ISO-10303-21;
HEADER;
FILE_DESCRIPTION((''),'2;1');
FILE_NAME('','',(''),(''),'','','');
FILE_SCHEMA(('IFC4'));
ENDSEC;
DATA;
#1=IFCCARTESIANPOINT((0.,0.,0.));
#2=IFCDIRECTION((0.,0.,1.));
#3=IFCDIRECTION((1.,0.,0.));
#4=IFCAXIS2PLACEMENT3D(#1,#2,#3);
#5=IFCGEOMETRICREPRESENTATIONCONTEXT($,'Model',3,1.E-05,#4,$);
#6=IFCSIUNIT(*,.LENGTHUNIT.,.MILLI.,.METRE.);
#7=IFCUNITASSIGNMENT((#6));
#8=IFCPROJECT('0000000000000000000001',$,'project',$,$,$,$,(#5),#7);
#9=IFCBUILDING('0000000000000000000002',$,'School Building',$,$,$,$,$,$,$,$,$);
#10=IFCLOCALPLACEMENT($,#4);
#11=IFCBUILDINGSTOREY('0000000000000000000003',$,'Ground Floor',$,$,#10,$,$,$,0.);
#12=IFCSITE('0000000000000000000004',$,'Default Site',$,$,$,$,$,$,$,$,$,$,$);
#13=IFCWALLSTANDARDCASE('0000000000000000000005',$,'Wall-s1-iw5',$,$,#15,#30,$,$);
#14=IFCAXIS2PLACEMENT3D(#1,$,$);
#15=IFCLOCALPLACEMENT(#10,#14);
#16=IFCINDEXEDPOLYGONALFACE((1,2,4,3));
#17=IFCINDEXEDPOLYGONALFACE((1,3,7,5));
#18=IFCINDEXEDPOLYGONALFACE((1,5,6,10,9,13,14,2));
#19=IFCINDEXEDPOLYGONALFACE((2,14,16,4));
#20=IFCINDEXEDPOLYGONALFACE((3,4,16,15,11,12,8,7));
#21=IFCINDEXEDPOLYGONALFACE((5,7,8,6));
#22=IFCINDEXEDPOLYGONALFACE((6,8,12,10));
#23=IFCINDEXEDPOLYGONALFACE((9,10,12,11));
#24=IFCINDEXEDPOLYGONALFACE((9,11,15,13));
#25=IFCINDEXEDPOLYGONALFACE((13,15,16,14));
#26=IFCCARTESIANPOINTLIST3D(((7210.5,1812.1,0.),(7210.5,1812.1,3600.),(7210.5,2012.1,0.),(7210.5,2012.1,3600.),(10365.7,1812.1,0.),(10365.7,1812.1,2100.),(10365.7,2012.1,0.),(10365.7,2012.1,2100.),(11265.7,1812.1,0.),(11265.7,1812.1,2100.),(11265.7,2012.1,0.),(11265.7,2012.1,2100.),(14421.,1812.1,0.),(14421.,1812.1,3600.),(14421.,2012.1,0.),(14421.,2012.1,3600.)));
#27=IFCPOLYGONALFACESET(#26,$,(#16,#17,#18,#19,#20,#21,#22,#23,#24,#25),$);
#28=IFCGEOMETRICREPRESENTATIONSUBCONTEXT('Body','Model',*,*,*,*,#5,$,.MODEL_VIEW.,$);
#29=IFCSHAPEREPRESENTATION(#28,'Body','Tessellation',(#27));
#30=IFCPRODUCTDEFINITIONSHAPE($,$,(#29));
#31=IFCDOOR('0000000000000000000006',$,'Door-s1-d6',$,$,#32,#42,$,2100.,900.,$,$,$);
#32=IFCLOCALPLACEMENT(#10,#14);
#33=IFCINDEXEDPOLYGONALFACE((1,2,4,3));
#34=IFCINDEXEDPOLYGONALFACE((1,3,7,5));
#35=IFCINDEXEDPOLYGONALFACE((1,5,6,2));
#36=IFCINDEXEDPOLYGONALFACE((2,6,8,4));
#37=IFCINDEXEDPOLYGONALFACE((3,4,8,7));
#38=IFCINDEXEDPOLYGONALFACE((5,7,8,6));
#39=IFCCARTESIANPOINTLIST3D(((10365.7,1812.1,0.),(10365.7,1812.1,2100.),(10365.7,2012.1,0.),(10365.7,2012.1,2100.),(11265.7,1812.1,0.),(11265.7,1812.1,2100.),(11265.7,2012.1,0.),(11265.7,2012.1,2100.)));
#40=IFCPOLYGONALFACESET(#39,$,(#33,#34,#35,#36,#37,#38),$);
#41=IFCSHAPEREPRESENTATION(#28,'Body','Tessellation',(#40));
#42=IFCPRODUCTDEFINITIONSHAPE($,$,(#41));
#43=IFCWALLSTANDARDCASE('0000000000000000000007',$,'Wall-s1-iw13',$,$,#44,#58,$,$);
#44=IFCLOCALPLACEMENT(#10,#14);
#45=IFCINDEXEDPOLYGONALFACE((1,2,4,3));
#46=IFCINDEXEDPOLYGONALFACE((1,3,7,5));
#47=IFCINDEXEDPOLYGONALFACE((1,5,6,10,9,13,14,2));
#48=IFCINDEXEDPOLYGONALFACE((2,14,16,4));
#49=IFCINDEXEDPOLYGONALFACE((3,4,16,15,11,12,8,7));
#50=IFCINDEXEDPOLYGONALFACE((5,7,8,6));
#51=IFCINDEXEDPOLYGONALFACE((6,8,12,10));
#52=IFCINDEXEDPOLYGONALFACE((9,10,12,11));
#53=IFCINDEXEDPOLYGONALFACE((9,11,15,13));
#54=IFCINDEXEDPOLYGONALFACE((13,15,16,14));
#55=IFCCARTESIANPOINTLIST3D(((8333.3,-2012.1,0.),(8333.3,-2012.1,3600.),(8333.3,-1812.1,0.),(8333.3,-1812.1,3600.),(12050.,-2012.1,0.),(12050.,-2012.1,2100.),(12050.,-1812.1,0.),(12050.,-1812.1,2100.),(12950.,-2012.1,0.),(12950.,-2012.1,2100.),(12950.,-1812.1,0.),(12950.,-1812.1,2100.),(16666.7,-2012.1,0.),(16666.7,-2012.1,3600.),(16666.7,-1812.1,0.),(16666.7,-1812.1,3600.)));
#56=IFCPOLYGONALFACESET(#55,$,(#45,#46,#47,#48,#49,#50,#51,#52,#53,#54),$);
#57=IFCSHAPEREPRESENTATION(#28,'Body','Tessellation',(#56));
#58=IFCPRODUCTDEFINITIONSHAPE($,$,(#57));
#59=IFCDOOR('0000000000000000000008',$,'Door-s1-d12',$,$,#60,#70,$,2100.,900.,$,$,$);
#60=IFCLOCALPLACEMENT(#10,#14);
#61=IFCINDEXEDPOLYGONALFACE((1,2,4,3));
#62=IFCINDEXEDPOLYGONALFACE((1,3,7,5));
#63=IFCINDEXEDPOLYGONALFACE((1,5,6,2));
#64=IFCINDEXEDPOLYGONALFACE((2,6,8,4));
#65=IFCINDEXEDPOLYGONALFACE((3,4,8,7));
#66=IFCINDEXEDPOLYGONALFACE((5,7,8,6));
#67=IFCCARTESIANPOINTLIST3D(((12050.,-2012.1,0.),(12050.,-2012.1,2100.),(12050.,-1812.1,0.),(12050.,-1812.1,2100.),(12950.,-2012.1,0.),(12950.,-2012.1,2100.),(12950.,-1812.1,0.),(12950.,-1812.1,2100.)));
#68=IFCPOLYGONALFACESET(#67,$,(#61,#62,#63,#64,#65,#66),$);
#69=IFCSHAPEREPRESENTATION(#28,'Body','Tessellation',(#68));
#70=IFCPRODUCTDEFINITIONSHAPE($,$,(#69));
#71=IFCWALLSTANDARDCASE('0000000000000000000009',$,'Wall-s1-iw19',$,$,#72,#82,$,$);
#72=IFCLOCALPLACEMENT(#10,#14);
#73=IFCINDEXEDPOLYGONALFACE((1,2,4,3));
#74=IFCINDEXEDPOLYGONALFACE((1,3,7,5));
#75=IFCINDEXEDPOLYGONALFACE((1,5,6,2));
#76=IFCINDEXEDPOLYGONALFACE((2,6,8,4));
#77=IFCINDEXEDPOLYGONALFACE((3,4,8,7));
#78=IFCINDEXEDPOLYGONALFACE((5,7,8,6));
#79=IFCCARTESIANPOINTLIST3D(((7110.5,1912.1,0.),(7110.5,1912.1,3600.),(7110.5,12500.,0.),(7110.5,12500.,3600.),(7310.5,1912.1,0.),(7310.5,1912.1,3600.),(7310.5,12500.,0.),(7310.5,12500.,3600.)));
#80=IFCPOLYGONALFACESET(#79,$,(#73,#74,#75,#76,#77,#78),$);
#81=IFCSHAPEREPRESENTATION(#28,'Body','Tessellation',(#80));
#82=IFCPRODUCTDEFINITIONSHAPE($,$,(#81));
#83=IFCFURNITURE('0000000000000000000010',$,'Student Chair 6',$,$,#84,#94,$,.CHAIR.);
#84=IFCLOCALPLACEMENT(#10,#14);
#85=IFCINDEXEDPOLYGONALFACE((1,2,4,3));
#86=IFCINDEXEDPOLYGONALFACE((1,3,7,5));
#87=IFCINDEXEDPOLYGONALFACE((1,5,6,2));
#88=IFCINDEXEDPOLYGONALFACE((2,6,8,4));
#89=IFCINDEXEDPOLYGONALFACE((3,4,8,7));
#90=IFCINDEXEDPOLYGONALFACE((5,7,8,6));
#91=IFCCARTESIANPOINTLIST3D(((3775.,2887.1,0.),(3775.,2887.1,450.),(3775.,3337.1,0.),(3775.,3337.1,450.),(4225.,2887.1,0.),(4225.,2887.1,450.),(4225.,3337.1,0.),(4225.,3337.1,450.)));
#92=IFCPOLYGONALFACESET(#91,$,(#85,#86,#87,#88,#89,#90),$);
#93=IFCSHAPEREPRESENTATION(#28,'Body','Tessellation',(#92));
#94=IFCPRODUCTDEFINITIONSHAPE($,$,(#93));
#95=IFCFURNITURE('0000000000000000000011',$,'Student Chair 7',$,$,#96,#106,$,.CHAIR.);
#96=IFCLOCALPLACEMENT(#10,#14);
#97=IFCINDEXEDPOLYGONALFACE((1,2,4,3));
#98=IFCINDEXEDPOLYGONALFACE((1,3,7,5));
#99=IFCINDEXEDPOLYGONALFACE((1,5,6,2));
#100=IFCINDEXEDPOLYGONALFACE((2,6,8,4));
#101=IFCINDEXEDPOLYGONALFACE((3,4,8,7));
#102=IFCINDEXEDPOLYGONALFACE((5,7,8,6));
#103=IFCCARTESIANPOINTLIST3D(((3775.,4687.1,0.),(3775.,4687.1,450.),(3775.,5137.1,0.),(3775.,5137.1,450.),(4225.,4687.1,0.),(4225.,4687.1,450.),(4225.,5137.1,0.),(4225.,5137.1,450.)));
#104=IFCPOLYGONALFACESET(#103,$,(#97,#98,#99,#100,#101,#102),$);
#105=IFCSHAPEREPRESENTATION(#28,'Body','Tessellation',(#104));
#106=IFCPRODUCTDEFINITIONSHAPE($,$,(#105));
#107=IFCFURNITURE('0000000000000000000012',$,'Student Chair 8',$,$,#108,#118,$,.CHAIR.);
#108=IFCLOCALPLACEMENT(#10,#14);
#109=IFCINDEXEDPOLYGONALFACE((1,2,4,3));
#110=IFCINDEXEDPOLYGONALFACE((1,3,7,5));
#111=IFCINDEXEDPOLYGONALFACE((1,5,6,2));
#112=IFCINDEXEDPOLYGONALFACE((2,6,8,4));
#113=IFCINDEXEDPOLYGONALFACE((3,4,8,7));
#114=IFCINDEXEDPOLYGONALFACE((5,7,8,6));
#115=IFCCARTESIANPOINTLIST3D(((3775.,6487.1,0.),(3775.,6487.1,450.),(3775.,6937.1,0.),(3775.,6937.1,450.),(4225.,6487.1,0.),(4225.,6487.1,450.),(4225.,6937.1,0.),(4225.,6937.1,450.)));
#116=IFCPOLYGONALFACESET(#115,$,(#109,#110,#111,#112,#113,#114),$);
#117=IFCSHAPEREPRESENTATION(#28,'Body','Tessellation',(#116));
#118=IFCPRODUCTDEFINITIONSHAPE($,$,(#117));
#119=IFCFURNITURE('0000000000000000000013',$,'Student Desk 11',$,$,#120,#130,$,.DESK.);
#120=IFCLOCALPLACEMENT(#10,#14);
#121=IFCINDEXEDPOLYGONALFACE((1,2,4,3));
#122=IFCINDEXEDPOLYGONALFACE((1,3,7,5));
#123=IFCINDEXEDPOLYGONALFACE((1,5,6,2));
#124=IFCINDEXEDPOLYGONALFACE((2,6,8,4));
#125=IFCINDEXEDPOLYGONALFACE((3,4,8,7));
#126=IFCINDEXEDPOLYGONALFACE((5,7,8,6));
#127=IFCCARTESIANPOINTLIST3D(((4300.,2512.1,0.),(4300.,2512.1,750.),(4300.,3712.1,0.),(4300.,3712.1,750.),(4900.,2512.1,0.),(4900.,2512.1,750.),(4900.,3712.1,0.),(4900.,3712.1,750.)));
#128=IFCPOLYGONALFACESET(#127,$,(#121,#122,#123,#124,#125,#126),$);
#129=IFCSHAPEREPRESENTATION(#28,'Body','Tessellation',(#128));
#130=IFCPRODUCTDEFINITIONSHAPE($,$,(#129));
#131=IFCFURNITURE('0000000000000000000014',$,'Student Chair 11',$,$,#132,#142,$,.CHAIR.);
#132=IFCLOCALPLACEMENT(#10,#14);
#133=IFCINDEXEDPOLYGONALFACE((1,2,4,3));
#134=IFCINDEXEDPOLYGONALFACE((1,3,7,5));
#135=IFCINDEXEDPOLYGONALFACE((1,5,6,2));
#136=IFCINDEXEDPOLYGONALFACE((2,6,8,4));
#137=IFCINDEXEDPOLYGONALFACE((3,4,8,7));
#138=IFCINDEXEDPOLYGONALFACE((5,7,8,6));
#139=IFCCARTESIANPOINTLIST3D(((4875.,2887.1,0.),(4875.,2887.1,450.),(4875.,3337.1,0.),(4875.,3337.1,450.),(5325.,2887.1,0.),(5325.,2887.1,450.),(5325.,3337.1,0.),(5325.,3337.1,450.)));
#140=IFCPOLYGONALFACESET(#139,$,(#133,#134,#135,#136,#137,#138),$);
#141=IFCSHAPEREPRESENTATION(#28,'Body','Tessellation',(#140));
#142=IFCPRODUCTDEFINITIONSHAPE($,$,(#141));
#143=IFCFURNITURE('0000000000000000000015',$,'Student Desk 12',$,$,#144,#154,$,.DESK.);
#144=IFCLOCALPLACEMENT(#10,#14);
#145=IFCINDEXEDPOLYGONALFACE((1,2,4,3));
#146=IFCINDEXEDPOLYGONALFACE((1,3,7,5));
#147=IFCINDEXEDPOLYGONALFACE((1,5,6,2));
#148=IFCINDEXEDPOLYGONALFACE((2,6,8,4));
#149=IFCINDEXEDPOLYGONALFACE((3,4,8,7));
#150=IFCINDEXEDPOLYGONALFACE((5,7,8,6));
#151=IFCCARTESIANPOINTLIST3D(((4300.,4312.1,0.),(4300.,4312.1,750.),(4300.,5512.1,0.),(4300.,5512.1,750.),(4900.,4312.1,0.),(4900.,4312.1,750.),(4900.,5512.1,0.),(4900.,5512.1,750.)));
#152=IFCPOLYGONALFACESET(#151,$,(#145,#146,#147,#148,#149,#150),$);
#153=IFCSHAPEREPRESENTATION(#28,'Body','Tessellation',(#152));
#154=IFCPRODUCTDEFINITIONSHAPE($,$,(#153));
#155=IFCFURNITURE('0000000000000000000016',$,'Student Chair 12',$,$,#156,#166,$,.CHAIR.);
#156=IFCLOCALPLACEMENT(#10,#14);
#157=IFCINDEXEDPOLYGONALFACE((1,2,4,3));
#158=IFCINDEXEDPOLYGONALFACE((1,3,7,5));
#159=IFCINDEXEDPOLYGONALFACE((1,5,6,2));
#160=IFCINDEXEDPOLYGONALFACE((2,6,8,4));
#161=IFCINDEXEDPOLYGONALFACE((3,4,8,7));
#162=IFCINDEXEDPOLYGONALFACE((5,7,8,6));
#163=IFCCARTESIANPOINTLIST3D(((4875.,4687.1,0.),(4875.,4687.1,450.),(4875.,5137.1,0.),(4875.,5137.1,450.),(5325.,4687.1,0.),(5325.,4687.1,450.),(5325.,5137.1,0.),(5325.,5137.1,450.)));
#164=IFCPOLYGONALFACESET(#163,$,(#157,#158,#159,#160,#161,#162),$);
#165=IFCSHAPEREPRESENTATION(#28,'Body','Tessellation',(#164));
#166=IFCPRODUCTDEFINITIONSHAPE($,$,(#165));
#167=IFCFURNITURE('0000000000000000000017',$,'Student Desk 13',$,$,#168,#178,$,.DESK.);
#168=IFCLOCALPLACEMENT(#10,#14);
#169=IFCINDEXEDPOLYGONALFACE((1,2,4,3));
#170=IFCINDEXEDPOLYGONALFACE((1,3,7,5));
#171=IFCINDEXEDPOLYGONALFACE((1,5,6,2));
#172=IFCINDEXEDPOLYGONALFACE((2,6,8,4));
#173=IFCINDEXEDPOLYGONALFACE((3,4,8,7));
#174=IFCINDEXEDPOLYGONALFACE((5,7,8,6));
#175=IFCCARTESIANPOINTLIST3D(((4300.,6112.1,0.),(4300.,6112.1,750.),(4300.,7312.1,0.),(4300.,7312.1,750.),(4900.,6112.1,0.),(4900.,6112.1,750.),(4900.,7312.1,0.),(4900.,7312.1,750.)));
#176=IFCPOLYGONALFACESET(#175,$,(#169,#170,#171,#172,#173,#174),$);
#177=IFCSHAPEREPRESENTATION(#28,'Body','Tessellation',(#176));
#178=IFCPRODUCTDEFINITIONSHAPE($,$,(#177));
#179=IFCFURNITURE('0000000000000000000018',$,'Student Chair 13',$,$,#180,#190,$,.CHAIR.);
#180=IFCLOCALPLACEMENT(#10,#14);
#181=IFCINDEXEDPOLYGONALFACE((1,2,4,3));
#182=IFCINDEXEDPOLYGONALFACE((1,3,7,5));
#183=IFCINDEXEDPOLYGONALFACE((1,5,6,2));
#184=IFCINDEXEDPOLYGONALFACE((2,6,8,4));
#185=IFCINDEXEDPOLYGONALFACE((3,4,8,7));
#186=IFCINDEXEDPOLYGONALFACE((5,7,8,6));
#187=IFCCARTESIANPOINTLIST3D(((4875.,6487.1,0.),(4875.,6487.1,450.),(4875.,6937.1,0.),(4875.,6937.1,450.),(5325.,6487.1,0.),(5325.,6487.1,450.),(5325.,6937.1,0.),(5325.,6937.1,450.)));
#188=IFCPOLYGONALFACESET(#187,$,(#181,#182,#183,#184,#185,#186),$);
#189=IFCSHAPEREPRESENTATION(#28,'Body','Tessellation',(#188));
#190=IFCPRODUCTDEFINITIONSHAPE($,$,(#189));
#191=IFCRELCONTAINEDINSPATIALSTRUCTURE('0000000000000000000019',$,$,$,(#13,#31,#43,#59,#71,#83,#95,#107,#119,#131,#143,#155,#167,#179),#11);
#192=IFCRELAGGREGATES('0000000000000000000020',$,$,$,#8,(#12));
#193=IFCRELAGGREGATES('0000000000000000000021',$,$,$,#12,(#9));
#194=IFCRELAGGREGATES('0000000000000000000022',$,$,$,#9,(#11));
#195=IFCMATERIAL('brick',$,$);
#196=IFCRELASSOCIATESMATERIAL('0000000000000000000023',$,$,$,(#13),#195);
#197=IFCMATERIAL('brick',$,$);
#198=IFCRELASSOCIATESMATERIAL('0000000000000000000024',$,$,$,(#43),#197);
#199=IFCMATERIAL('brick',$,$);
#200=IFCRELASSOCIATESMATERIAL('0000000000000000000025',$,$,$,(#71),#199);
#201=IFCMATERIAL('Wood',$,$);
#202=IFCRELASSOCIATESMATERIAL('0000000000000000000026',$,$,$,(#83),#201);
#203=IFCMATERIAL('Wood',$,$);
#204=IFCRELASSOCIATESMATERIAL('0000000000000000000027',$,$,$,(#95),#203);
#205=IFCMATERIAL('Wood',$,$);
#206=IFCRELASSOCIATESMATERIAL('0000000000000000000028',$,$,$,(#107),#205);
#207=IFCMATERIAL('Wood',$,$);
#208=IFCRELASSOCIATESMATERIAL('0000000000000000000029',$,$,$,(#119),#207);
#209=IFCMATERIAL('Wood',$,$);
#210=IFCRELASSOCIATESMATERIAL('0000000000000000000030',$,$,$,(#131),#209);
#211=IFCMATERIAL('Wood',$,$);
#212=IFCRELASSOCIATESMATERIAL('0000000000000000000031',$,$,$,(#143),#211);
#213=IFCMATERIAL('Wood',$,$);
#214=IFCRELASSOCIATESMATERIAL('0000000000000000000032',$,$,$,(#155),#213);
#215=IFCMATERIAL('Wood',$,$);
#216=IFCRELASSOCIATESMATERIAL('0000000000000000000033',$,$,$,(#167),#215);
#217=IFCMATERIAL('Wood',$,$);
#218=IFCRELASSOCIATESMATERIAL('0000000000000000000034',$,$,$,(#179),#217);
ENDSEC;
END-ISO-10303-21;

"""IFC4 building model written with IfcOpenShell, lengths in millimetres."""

from ifc_helpers import new_model, si_unit, frame, frame_2d, origin_with_axes, origin_2d, place, context, subcontext, project, spatial, rectangle, extrude, material, element, fill, save


model = new_model("IFC4")

# Units and contexts
model_context = context("Model", 3, precision=1e-05, world=origin_with_axes())
body_context = subcontext(model_context, "Body", "Model", "MODEL_VIEW")
ifc_project = project(units=[si_unit("LENGTHUNIT", "METRE", prefix="MILLI")], contexts=[model_context])

# Site, building, storey
site = spatial("IfcSite", under=ifc_project, Name="Default Site")
building = spatial("IfcBuilding", under=site, Name="School Building")
storey_placement = place(None, origin_with_axes())
storey = spatial("IfcBuildingStorey", under=building, at=storey_placement, Name="Ground Floor", Elevation=0.0)

# Walls, openings, doors
ifc_material_1 = material(Name="brick")
wall_1_placement = place(storey_placement, frame((7210.5, 1912.1, 0.0), z_axis=(0.0, 0.0, 1.0), x_axis=(1.0, 0.0, 0.0)))
wall_1 = element("IfcWallStandardCase", 1, at=wall_1_placement, inside=storey, material=ifc_material_1, Name="Wall-s1-iw5", context=body_context, shape_type="SweptSolid", body=[
    extrude(rectangle(XDim=7210.5, YDim=200.0, at=frame_2d((3605.2, 0.0))), origin_with_axes(), (0.0, 0.0, 1.0), 3600.0),
])
opening_1_placement = place(wall_1_placement, frame((3155.2, 0.0, 0.0), z_axis=(0.0, 0.0, 1.0), x_axis=(1.0, 0.0, 0.0)))
opening_1 = element("IfcOpeningElement", 2, at=opening_1_placement, cuts=wall_1, context=body_context, shape_type="SweptSolid", body=[
    extrude(rectangle(XDim=900.0, YDim=400.0, at=frame_2d((450.0, 0.0))), origin_with_axes(), (0.0, 0.0, 1.0), 2100.0),
])
door_1_placement = place(storey_placement, frame((10365.7, 1912.1, 0.0), z_axis=(0.0, 0.0, 1.0), x_axis=(1.0, 0.0, 0.0)))
door_1 = element("IfcDoor", 3, at=door_1_placement, inside=storey, Name="Door-s1-d6", OverallHeight=2100.0, OverallWidth=900.0, context=body_context, shape_type="SweptSolid", body=[
    extrude(rectangle(XDim=900.0, YDim=200.0, at=frame_2d((450.0, 0.0))), origin_with_axes(), (0.0, 0.0, 1.0), 2100.0),
])
fill(opening_1, door_1)
ifc_material_2 = material(Name="brick")
wall_2_placement = place(storey_placement, frame((8333.3, -1912.1, 0.0), z_axis=(0.0, 0.0, 1.0), x_axis=(1.0, 0.0, 0.0)))
wall_2 = element("IfcWallStandardCase", 4, at=wall_2_placement, inside=storey, material=ifc_material_2, Name="Wall-s1-iw13", context=body_context, shape_type="SweptSolid", body=[
    extrude(rectangle(XDim=8333.3, YDim=200.0, at=frame_2d((4166.7, 0.0))), origin_with_axes(), (0.0, 0.0, 1.0), 3600.0),
])
opening_2_placement = place(wall_2_placement, frame((3716.7, 0.0, 0.0), z_axis=(0.0, 0.0, 1.0), x_axis=(1.0, 0.0, 0.0)))
opening_2 = element("IfcOpeningElement", 5, at=opening_2_placement, cuts=wall_2, context=body_context, shape_type="SweptSolid", body=[
    extrude(rectangle(XDim=900.0, YDim=400.0, at=frame_2d((450.0, 0.0))), origin_with_axes(), (0.0, 0.0, 1.0), 2100.0),
])
door_2_placement = place(storey_placement, frame((12050.0, -1912.1, 0.0), z_axis=(0.0, 0.0, 1.0), x_axis=(1.0, 0.0, 0.0)))
door_2 = element("IfcDoor", 6, at=door_2_placement, inside=storey, Name="Door-s1-d12", OverallHeight=2100.0, OverallWidth=900.0, context=body_context, shape_type="SweptSolid", body=[
    extrude(rectangle(XDim=900.0, YDim=200.0, at=frame_2d((450.0, 0.0))), origin_with_axes(), (0.0, 0.0, 1.0), 2100.0),
])
fill(opening_2, door_2)

# Wall
ifc_material_3 = material(Name="brick")
wall_3_placement = place(storey_placement, frame((7210.5, 1912.1, 0.0), z_axis=(0.0, 0.0, 1.0), x_axis=(0.0, 1.0, 0.0)))
element("IfcWallStandardCase", 7, at=wall_3_placement, inside=storey, material=ifc_material_3, Name="Wall-s1-iw19", context=body_context, shape_type="SweptSolid", body=[
    extrude(rectangle(XDim=10587.9, YDim=200.0, at=frame_2d((5293.9, 0.0))), origin_with_axes(), (0.0, 0.0, 1.0), 3600.0),
])

# Furniture
ifc_material_4 = material(Name="Wood")
furniture_1_placement = place(storey_placement, frame((4000.0, 3112.1, 0.0), z_axis=(0.0, 0.0, 1.0), x_axis=(1.0, 0.0, 0.0)))
element("IfcFurniture", 8, at=furniture_1_placement, inside=storey, material=ifc_material_4, Name="Student Chair 6", PredefinedType="CHAIR", context=body_context, shape_type="SweptSolid", body=[
    extrude(rectangle(XDim=450.0, YDim=450.0, at=origin_2d()), origin_with_axes(), (0.0, 0.0, 1.0), 450.0),
])
ifc_material_5 = material(Name="Wood")
furniture_2_placement = place(storey_placement, frame((4000.0, 4912.1, 0.0), z_axis=(0.0, 0.0, 1.0), x_axis=(1.0, 0.0, 0.0)))
element("IfcFurniture", 9, at=furniture_2_placement, inside=storey, material=ifc_material_5, Name="Student Chair 7", PredefinedType="CHAIR", context=body_context, shape_type="SweptSolid", body=[
    extrude(rectangle(XDim=450.0, YDim=450.0, at=origin_2d()), origin_with_axes(), (0.0, 0.0, 1.0), 450.0),
])
ifc_material_6 = material(Name="Wood")
furniture_3_placement = place(storey_placement, frame((4000.0, 6712.1, 0.0), z_axis=(0.0, 0.0, 1.0), x_axis=(1.0, 0.0, 0.0)))
element("IfcFurniture", 10, at=furniture_3_placement, inside=storey, material=ifc_material_6, Name="Student Chair 8", PredefinedType="CHAIR", context=body_context, shape_type="SweptSolid", body=[
    extrude(rectangle(XDim=450.0, YDim=450.0, at=origin_2d()), origin_with_axes(), (0.0, 0.0, 1.0), 450.0),
])
ifc_material_7 = material(Name="Wood")
furniture_4_placement = place(storey_placement, frame((4600.0, 3112.1, 0.0), z_axis=(0.0, 0.0, 1.0), x_axis=(0.0, 1.0, 0.0)))
element("IfcFurniture", 11, at=furniture_4_placement, inside=storey, material=ifc_material_7, Name="Student Desk 11", PredefinedType="DESK", context=body_context, shape_type="SweptSolid", body=[
    extrude(rectangle(XDim=1200.0, YDim=600.0, at=origin_2d()), origin_with_axes(), (0.0, 0.0, 1.0), 750.0),
])
ifc_material_8 = material(Name="Wood")
furniture_5_placement = place(storey_placement, frame((5100.0, 3112.1, 0.0), z_axis=(0.0, 0.0, 1.0), x_axis=(1.0, 0.0, 0.0)))
element("IfcFurniture", 12, at=furniture_5_placement, inside=storey, material=ifc_material_8, Name="Student Chair 11", PredefinedType="CHAIR", context=body_context, shape_type="SweptSolid", body=[
    extrude(rectangle(XDim=450.0, YDim=450.0, at=origin_2d()), origin_with_axes(), (0.0, 0.0, 1.0), 450.0),
])
ifc_material_9 = material(Name="Wood")
furniture_6_placement = place(storey_placement, frame((4600.0, 4912.1, 0.0), z_axis=(0.0, 0.0, 1.0), x_axis=(0.0, 1.0, 0.0)))
element("IfcFurniture", 13, at=furniture_6_placement, inside=storey, material=ifc_material_9, Name="Student Desk 12", PredefinedType="DESK", context=body_context, shape_type="SweptSolid", body=[
    extrude(rectangle(XDim=1200.0, YDim=600.0, at=origin_2d()), origin_with_axes(), (0.0, 0.0, 1.0), 750.0),
])
ifc_material_10 = material(Name="Wood")
furniture_7_placement = place(storey_placement, frame((5100.0, 4912.1, 0.0), z_axis=(0.0, 0.0, 1.0), x_axis=(1.0, 0.0, 0.0)))
element("IfcFurniture", 14, at=furniture_7_placement, inside=storey, material=ifc_material_10, Name="Student Chair 12", PredefinedType="CHAIR", context=body_context, shape_type="SweptSolid", body=[
    extrude(rectangle(XDim=450.0, YDim=450.0, at=origin_2d()), origin_with_axes(), (0.0, 0.0, 1.0), 450.0),
])
ifc_material_11 = material(Name="Wood")
furniture_8_placement = place(storey_placement, frame((4600.0, 6712.1, 0.0), z_axis=(0.0, 0.0, 1.0), x_axis=(0.0, 1.0, 0.0)))
element("IfcFurniture", 15, at=furniture_8_placement, inside=storey, material=ifc_material_11, Name="Student Desk 13", PredefinedType="DESK", context=body_context, shape_type="SweptSolid", body=[
    extrude(rectangle(XDim=1200.0, YDim=600.0, at=origin_2d()), origin_with_axes(), (0.0, 0.0, 1.0), 750.0),
])
ifc_material_12 = material(Name="Wood")
furniture_9_placement = place(storey_placement, frame((5100.0, 6712.1, 0.0), z_axis=(0.0, 0.0, 1.0), x_axis=(1.0, 0.0, 0.0)))
element("IfcFurniture", 16, at=furniture_9_placement, inside=storey, material=ifc_material_12, Name="Student Chair 13", PredefinedType="CHAIR", context=body_context, shape_type="SweptSolid", body=[
    extrude(rectangle(XDim=450.0, YDim=450.0, at=origin_2d()), origin_with_axes(), (0.0, 0.0, 1.0), 450.0),
])

save(model, "model.ifc")
